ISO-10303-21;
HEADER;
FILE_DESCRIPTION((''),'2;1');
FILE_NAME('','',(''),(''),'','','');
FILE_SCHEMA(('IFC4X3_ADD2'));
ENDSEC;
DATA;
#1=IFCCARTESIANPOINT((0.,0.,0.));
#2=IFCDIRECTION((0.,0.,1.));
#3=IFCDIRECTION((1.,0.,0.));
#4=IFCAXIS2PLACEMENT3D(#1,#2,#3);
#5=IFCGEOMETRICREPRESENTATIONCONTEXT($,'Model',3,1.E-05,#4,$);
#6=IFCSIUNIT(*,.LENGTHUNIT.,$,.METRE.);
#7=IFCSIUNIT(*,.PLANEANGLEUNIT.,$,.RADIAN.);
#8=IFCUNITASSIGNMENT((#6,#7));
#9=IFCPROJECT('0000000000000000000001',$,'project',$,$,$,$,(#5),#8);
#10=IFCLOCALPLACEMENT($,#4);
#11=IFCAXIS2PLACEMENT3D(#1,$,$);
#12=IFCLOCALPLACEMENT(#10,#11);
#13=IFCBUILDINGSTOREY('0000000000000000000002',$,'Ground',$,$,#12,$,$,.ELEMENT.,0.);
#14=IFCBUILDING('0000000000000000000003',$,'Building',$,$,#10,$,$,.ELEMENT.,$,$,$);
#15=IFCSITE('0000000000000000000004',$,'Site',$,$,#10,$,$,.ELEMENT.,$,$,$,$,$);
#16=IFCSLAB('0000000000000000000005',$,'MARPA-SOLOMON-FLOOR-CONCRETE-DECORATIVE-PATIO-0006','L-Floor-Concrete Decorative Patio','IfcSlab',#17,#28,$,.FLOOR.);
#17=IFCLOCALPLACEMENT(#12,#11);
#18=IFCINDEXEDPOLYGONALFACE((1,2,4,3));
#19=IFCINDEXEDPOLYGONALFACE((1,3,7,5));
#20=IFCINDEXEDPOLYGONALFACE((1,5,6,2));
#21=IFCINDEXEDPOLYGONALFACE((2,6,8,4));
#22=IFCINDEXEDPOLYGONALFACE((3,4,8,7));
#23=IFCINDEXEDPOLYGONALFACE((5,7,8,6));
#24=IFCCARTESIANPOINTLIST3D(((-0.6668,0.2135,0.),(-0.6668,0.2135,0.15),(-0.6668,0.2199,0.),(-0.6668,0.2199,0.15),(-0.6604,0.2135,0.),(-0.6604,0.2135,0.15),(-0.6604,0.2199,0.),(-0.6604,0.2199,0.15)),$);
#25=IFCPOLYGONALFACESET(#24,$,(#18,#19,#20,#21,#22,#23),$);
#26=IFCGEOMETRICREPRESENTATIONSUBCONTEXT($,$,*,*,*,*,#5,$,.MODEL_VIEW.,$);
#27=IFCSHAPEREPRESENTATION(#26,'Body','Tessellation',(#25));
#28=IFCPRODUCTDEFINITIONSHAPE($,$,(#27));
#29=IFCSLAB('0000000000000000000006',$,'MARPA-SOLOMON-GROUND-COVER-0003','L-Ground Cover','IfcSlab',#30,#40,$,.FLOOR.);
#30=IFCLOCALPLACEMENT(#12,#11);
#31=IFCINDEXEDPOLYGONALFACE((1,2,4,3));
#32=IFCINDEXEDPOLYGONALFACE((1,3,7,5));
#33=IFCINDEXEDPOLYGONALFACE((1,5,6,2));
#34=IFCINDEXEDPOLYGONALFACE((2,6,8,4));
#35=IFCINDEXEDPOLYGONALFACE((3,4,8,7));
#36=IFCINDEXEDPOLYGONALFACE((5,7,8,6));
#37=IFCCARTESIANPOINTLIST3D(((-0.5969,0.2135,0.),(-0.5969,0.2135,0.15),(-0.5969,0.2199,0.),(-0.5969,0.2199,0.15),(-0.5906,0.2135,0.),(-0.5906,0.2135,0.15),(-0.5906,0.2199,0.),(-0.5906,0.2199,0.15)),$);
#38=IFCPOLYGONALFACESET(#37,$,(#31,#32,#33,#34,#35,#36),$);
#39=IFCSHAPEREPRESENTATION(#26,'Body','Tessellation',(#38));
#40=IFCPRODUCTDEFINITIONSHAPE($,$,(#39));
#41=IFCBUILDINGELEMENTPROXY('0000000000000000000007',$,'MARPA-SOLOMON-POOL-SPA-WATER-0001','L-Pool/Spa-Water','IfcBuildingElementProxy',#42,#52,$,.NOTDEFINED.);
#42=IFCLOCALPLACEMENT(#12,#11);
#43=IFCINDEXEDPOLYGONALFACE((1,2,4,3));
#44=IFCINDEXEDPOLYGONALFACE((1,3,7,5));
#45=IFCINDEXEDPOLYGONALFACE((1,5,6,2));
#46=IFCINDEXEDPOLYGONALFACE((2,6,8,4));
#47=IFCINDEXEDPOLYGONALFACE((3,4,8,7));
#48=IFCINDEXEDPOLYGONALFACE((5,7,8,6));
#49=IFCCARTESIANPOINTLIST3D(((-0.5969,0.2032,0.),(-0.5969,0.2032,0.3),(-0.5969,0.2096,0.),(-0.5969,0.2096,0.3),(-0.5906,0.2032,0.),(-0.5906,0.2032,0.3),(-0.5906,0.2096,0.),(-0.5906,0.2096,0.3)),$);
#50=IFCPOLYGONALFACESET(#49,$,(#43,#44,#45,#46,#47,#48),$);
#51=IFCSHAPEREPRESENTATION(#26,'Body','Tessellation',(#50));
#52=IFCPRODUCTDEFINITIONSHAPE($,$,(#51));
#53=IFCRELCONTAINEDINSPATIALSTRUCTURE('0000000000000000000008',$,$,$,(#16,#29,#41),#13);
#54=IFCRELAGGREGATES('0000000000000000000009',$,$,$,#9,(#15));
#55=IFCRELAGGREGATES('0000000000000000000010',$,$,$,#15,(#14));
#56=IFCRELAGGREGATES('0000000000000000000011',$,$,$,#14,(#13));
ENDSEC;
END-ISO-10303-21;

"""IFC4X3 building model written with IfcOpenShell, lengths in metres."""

from ifc_helpers import new_model, si_unit, frame, origin, origin_with_axes, place, context, subcontext, project, spatial, polyline, outline, extrude, element, save


model = new_model("IFC4X3")

# Units and contexts
model_context = context("Model", 3, precision=1e-05, world=origin_with_axes())
sub_context = subcontext(model_context, None, None, "MODEL_VIEW")
ifc_project = project(units=[si_unit("LENGTHUNIT", "METRE"), si_unit("PLANEANGLEUNIT", "RADIAN")], contexts=[model_context])

# Site, building, storey
placement = place(None, origin_with_axes())
site = spatial("IfcSite", under=ifc_project, at=placement, Name="Site", CompositionType="ELEMENT")
building = spatial("IfcBuilding", under=site, at=placement, Name="Building", CompositionType="ELEMENT")
storey_placement = place(placement, origin())
storey = spatial("IfcBuildingStorey", under=building, at=storey_placement, Name="Ground", CompositionType="ELEMENT", Elevation=0.0)

# Slabs
for number, where, name in (
    (1, (-0.6668, 0.2135, 0.0), "MARPA-SOLOMON-FLOOR-CONCRETE-DECORATIVE-PATIO-0006"),
):
    element("IfcSlab", number, at=place(storey_placement, frame(where)), inside=storey, Name=name, Description="L-Floor-Concrete Decorative Patio", ObjectType="IfcSlab", PredefinedType="FLOOR", context=sub_context, shape_type="SweptSolid", body=[
        extrude(outline(polyline([(0.0, 0.0063), (0.0063, 0.0063), (0.0063, 0.0), (0.0, 0.0), (0.0, 0.0063)])), origin(), (0.0, 0.0, 1.0), 0.15),
    ])
slab_placement = place(storey_placement, frame((-0.5969, 0.2135, 0.0)))
element("IfcSlab", 2, at=slab_placement, inside=storey, Name="MARPA-SOLOMON-GROUND-COVER-0003", Description="L-Ground Cover", ObjectType="IfcSlab", PredefinedType="FLOOR", context=sub_context, shape_type="SweptSolid", body=[
    extrude(outline(polyline([(0.0, 0.0063), (0.0063, 0.0063), (0.0063, 0.0), (0.0, 0.0), (0.0, 0.0063)])), origin(), (0.0, 0.0, 1.0), 0.15),
])

# Building element proxy
for number, where, name in (
    (3, (-0.5969, 0.2032, 0.0), "MARPA-SOLOMON-POOL-SPA-WATER-0001"),
):
    element("IfcBuildingElementProxy", number, at=place(placement, frame(where)), inside=storey, Name=name, Description="L-Pool/Spa-Water", ObjectType="IfcBuildingElementProxy", PredefinedType="NOTDEFINED", context=sub_context, shape_type="SweptSolid", body=[
        extrude(outline(polyline([(0.0, 0.0063), (0.0063, 0.0063), (0.0063, 0.0), (0.0, 0.0), (0.0, 0.0063)])), origin(), (0.0, 0.0, 1.0), 0.3),
    ])

save(model, "model.ifc")
